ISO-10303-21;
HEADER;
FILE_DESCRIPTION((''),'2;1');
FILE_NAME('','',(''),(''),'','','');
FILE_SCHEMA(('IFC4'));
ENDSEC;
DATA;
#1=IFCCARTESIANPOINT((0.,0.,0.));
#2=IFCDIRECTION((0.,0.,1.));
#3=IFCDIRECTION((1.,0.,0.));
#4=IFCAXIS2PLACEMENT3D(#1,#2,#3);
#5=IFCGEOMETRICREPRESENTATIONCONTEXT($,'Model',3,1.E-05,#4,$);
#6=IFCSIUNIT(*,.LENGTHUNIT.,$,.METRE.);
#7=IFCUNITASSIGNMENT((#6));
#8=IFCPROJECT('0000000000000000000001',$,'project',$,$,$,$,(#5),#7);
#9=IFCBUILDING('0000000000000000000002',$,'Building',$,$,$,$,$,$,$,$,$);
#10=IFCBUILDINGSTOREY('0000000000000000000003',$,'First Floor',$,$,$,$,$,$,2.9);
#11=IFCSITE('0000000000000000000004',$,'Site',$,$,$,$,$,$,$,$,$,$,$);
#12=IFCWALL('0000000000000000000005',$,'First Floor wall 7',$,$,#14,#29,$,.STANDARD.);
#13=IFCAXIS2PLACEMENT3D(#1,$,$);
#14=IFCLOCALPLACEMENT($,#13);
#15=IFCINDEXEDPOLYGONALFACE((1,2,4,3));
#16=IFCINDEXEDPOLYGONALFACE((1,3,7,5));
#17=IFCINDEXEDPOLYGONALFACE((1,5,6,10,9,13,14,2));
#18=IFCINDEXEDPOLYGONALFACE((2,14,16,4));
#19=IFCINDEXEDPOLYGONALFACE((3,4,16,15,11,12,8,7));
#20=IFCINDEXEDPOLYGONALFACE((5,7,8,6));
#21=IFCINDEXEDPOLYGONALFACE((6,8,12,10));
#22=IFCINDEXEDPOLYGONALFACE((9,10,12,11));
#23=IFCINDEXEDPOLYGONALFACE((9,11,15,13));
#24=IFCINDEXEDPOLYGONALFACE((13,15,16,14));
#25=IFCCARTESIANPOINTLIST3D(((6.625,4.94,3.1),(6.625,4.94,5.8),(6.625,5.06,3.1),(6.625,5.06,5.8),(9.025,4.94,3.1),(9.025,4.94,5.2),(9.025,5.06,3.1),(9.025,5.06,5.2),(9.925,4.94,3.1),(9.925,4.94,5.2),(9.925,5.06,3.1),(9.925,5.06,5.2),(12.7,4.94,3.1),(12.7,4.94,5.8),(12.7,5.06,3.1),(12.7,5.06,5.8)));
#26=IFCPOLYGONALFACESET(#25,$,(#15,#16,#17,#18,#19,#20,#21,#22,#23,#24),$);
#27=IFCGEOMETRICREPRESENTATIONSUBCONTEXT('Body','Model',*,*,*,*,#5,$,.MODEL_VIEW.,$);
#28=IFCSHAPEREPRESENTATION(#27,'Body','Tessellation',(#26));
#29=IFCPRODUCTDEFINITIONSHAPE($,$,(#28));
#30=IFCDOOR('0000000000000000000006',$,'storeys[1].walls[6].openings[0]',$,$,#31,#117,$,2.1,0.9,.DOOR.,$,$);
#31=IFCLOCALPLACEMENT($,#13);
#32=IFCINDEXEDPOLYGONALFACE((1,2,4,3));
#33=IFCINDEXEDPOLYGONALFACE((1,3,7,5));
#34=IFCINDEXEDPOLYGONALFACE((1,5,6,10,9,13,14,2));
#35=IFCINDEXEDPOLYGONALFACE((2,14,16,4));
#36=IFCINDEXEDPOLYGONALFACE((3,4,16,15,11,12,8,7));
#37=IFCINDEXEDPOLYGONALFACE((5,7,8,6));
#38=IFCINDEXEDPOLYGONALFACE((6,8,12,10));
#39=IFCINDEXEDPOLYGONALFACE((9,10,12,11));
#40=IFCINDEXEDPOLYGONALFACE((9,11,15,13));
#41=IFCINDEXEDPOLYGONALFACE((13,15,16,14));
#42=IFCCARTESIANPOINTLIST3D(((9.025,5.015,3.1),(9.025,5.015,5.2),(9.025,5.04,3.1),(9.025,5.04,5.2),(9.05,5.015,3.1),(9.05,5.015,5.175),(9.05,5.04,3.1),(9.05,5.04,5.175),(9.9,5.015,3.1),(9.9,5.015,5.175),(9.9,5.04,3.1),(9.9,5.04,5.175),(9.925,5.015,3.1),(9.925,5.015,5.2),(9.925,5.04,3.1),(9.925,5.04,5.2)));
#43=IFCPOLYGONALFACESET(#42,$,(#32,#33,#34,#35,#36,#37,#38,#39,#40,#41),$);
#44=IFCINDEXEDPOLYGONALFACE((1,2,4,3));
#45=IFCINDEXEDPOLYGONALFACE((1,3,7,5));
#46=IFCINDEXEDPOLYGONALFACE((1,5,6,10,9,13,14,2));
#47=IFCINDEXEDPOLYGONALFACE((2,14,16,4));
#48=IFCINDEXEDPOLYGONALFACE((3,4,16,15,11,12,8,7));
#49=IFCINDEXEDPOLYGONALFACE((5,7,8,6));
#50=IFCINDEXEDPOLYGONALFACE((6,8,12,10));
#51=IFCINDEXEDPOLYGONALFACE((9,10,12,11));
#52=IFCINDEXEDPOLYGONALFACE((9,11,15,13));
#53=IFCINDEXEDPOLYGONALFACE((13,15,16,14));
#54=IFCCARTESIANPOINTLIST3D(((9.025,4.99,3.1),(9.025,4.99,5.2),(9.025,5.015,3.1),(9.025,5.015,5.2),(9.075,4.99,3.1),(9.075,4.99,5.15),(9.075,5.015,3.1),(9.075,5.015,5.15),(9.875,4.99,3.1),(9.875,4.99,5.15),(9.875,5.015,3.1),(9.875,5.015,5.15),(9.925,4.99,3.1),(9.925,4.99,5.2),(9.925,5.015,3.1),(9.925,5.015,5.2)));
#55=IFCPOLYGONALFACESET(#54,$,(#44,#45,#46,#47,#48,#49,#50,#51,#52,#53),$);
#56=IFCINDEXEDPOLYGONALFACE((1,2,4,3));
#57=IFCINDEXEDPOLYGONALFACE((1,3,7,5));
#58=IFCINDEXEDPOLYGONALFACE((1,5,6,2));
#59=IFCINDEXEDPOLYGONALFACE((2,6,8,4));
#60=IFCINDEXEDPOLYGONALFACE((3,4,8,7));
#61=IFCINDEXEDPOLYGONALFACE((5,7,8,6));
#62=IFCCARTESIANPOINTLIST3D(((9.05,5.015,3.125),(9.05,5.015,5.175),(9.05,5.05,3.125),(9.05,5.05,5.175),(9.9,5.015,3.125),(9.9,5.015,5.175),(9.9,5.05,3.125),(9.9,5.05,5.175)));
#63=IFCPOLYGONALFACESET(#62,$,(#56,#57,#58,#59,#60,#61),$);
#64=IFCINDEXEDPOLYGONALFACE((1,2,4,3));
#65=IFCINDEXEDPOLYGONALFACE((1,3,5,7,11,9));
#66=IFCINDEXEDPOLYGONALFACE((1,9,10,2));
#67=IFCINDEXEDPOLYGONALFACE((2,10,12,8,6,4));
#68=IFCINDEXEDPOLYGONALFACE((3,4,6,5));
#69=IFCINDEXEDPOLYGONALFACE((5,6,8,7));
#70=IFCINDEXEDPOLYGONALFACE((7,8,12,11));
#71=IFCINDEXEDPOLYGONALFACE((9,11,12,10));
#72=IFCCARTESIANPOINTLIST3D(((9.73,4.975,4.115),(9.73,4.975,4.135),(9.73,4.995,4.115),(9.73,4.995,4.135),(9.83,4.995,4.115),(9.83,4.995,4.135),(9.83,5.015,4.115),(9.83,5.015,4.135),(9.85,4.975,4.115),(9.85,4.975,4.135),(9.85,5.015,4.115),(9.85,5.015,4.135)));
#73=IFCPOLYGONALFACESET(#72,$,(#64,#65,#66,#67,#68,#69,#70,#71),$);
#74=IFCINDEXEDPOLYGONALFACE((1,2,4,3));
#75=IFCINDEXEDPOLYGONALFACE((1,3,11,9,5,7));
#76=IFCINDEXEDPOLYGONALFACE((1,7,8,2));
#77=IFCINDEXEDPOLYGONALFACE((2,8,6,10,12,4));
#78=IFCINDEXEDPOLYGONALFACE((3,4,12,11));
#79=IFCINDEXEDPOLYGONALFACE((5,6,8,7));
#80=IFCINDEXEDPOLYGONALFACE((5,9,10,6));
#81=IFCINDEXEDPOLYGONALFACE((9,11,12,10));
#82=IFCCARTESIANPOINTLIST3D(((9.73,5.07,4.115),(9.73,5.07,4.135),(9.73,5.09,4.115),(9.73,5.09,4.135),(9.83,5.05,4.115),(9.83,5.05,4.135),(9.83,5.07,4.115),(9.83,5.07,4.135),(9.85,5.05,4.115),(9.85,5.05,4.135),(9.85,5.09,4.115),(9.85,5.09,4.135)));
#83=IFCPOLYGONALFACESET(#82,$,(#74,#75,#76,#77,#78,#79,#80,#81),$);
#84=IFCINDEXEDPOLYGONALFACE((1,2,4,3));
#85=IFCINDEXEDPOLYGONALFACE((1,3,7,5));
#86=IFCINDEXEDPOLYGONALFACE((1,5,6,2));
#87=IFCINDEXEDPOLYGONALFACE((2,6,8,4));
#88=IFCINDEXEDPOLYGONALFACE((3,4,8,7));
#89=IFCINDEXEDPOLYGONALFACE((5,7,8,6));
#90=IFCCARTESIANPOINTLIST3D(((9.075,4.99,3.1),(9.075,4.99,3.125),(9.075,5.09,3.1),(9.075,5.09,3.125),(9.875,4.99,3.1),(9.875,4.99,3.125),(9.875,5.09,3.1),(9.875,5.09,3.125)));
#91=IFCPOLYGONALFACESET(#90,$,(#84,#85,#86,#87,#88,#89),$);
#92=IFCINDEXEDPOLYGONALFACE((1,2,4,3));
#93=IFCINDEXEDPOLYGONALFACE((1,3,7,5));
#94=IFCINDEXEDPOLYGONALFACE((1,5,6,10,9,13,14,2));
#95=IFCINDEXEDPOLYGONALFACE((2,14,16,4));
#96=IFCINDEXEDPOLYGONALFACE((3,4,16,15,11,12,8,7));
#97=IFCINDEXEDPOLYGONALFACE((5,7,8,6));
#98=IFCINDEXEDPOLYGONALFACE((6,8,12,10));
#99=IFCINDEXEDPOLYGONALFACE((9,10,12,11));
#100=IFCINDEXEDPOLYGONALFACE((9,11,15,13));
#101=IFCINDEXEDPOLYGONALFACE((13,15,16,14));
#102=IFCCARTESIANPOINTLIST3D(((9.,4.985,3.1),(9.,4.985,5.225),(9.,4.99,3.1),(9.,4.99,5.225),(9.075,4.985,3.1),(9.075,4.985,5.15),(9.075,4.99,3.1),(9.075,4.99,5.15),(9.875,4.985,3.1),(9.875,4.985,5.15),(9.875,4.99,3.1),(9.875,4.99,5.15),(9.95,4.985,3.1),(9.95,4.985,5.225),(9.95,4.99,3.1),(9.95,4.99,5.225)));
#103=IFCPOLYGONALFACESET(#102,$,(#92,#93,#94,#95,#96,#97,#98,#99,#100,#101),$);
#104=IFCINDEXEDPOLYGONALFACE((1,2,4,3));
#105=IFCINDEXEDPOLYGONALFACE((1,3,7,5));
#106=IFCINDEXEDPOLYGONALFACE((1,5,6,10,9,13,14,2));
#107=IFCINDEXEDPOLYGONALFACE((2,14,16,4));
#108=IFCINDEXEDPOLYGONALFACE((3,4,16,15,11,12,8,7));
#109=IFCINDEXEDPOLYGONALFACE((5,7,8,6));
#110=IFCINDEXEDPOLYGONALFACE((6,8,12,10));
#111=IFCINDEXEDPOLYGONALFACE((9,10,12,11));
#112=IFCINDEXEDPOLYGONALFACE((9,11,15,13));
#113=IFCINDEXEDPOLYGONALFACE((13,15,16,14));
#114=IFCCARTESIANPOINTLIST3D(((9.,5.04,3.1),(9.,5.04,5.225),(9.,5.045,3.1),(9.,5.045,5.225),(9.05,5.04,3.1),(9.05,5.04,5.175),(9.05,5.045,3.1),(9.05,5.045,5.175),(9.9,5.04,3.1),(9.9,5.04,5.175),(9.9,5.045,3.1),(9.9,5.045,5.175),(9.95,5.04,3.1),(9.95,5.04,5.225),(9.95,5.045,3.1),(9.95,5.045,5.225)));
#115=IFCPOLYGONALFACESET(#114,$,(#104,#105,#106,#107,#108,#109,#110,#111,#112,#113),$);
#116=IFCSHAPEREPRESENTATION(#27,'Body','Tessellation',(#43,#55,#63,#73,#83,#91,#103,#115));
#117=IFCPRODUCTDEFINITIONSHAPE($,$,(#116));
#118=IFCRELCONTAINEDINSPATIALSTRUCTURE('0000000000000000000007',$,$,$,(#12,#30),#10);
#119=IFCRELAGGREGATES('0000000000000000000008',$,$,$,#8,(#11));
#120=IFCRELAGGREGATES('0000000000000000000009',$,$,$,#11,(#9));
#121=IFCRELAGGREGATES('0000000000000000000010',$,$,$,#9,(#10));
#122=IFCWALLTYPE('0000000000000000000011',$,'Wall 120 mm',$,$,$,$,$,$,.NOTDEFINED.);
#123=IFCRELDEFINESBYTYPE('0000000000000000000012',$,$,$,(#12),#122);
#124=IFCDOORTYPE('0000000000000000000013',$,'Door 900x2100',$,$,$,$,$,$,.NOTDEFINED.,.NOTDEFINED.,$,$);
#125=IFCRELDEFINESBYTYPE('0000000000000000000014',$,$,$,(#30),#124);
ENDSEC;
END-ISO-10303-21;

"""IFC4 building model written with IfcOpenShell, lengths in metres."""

from ifc_helpers import new_model, si_unit, frame, origin_with_axes, place, context, subcontext, project, spatial, line, indexed_curve, outline, extrude, type_object, element, fill, save


model = new_model("IFC4")

# Units and contexts
model_context = context("Model", 3, precision=1e-05, world=origin_with_axes())
body_context = subcontext(model_context, "Body", "Model", "MODEL_VIEW")
ifc_project = project(units=[si_unit("LENGTHUNIT", "METRE")], contexts=[model_context])

# Site, building, storey
site = spatial("IfcSite", under=ifc_project, Name="Site")
building = spatial("IfcBuilding", under=site, Name="Building")
storey = spatial("IfcBuildingStorey", under=building, Name="First Floor", Elevation=2.9)

# Wall, opening, door
wall_type_1 = type_object("IfcWallType", Name="Wall 120 mm", PredefinedType="NOTDEFINED")
door_type = type_object("IfcDoorType", Name="Door 900x2100", OperationType="NOTDEFINED", PredefinedType="NOTDEFINED")
wall_1_placement = place(None, frame((6.625, 5.0, 3.1), z_axis=(0.0, 0.0, 1.0), x_axis=(1.0, 0.0, 0.0)))
wall_1 = element("IfcWall", 1, at=wall_1_placement, inside=storey, type_object=wall_type_1, Name="First Floor wall 7", PredefinedType="STANDARD", context=body_context, shape_type="SweptSolid", body=[
    extrude(outline(indexed_curve([(0.0, 0.0), (0.0, 0.12), (6.075, 0.12), (6.075, 0.0), (0.0, 0.0)], self_intersect=False)), frame((0.0, -0.06, 0.0), z_axis=(0.0, 0.0, 1.0), x_axis=(1.0, 0.0, 0.0)), (0.0, 0.0, 1.0), 2.7),
])
opening_1_placement = place(wall_1_placement, frame((2.4, -0.07, 0.0), z_axis=(0.0, 0.0, 1.0), x_axis=(1.0, 0.0, 0.0)))
opening_1 = element("IfcOpeningElement", 2, at=opening_1_placement, cuts=wall_1, context=body_context, shape_type="SweptSolid", body=[
    extrude(outline(indexed_curve([(0.0, 0.0), (0.0, 0.14), (0.9, 0.14), (0.9, 0.0), (0.0, 0.0)], self_intersect=False)), origin_with_axes(), (0.0, 0.0, 1.0), 2.1),
])
door_1_placement = place(None, frame((9.025, 4.99, 3.1), z_axis=(0.0, 0.0, 1.0), x_axis=(1.0, 0.0, 0.0)))
door_1 = element("IfcDoor", 3, at=door_1_placement, inside=storey, type_object=door_type, Name="storeys[1].walls[6].openings[0]", OverallHeight=2.1, OverallWidth=0.9, PredefinedType="DOOR", context=body_context, shape_type="SweptSolid", body=[
    extrude(outline(indexed_curve([(0.0, 0.0), (0.0, 2.1), (0.9, 2.1), (0.9, 0.0), (0.875, 0.0), (0.875, 2.075), (0.025, 2.075), (0.025, 0.0)], segments=[line(1, 2, 3, 4, 5, 6, 7, 8, 1)])), frame((0.0, 0.025, 0.0), z_axis=(0.0, -1.0, 0.0), x_axis=(1.0, 0.0, 0.0)), (0.0, 0.0, -1.0), 0.025),
    extrude(outline(indexed_curve([(0.0, 0.0), (0.0, 2.1), (0.9, 2.1), (0.9, 0.0), (0.85, 0.0), (0.85, 2.05), (0.05, 2.05), (0.05, 0.0)], segments=[line(1, 2, 3, 4, 5, 6, 7, 8, 1)])), frame((0.0, 0.0, 0.0), z_axis=(0.0, -1.0, 0.0), x_axis=(1.0, 0.0, 0.0)), (0.0, 0.0, -1.0), 0.025),
    extrude(outline(indexed_curve([(0.0, 0.0), (0.85, 0.0), (0.85, 0.035), (0.0, 0.035)], segments=[line(1, 2, 3, 4, 1)])), frame((0.025, 0.025, 0.025), z_axis=(0.0, 0.0, 1.0), x_axis=(1.0, 0.0, 0.0)), (0.0, 0.0, 1.0), 2.05),
    extrude(outline(indexed_curve([(0.0, 0.0), (0.0, -0.04), (-0.12, -0.04), (-0.12, -0.02), (-0.02, -0.02), (-0.02, 0.0)], segments=[line(1, 2, 3, 4, 5, 6, 1)])), frame((0.825, 0.025, 1.015), z_axis=(0.0, 0.0, 1.0), x_axis=(1.0, 0.0, 0.0)), (0.0, 0.0, 1.0), 0.02),
    extrude(outline(indexed_curve([(0.0, 0.0), (0.0, 0.04), (-0.12, 0.04), (-0.12, 0.02), (-0.02, 0.02), (-0.02, 0.0)], segments=[line(1, 2, 3, 4, 5, 6, 1)])), frame((0.825, 0.06, 1.015), z_axis=(0.0, 0.0, 1.0), x_axis=(1.0, 0.0, 0.0)), (0.0, 0.0, 1.0), 0.02),
    extrude(outline(indexed_curve([(0.0, 0.0), (0.8, 0.0), (0.8, 0.1), (0.0, 0.1)], segments=[line(1, 2, 3, 4, 1)])), frame((0.05, 0.0, 0.0), z_axis=(0.0, 0.0, 1.0), x_axis=(1.0, 0.0, 0.0)), (0.0, 0.0, 1.0), 0.025),
    extrude(outline(indexed_curve([(0.0, 0.0), (0.0, 2.125), (0.95, 2.125), (0.95, 0.0), (0.875, 0.0), (0.875, 2.05), (0.075, 2.05), (0.075, 0.0)], segments=[line(1, 2, 3, 4, 5, 6, 7, 8, 1)])), frame((-0.025, -0.005, 0.0), z_axis=(0.0, -1.0, 0.0), x_axis=(1.0, 0.0, 0.0)), (0.0, 0.0, -1.0), 0.005),
    extrude(outline(indexed_curve([(0.0, 0.0), (0.0, 2.125), (0.95, 2.125), (0.95, 0.0), (0.9, 0.0), (0.9, 2.075), (0.05, 2.075), (0.05, 0.0)], segments=[line(1, 2, 3, 4, 5, 6, 7, 8, 1)])), frame((-0.025, 0.05, 0.0), z_axis=(0.0, -1.0, 0.0), x_axis=(1.0, 0.0, 0.0)), (0.0, 0.0, -1.0), 0.005),
])
fill(opening_1, door_1)

save(model, "model.ifc")
